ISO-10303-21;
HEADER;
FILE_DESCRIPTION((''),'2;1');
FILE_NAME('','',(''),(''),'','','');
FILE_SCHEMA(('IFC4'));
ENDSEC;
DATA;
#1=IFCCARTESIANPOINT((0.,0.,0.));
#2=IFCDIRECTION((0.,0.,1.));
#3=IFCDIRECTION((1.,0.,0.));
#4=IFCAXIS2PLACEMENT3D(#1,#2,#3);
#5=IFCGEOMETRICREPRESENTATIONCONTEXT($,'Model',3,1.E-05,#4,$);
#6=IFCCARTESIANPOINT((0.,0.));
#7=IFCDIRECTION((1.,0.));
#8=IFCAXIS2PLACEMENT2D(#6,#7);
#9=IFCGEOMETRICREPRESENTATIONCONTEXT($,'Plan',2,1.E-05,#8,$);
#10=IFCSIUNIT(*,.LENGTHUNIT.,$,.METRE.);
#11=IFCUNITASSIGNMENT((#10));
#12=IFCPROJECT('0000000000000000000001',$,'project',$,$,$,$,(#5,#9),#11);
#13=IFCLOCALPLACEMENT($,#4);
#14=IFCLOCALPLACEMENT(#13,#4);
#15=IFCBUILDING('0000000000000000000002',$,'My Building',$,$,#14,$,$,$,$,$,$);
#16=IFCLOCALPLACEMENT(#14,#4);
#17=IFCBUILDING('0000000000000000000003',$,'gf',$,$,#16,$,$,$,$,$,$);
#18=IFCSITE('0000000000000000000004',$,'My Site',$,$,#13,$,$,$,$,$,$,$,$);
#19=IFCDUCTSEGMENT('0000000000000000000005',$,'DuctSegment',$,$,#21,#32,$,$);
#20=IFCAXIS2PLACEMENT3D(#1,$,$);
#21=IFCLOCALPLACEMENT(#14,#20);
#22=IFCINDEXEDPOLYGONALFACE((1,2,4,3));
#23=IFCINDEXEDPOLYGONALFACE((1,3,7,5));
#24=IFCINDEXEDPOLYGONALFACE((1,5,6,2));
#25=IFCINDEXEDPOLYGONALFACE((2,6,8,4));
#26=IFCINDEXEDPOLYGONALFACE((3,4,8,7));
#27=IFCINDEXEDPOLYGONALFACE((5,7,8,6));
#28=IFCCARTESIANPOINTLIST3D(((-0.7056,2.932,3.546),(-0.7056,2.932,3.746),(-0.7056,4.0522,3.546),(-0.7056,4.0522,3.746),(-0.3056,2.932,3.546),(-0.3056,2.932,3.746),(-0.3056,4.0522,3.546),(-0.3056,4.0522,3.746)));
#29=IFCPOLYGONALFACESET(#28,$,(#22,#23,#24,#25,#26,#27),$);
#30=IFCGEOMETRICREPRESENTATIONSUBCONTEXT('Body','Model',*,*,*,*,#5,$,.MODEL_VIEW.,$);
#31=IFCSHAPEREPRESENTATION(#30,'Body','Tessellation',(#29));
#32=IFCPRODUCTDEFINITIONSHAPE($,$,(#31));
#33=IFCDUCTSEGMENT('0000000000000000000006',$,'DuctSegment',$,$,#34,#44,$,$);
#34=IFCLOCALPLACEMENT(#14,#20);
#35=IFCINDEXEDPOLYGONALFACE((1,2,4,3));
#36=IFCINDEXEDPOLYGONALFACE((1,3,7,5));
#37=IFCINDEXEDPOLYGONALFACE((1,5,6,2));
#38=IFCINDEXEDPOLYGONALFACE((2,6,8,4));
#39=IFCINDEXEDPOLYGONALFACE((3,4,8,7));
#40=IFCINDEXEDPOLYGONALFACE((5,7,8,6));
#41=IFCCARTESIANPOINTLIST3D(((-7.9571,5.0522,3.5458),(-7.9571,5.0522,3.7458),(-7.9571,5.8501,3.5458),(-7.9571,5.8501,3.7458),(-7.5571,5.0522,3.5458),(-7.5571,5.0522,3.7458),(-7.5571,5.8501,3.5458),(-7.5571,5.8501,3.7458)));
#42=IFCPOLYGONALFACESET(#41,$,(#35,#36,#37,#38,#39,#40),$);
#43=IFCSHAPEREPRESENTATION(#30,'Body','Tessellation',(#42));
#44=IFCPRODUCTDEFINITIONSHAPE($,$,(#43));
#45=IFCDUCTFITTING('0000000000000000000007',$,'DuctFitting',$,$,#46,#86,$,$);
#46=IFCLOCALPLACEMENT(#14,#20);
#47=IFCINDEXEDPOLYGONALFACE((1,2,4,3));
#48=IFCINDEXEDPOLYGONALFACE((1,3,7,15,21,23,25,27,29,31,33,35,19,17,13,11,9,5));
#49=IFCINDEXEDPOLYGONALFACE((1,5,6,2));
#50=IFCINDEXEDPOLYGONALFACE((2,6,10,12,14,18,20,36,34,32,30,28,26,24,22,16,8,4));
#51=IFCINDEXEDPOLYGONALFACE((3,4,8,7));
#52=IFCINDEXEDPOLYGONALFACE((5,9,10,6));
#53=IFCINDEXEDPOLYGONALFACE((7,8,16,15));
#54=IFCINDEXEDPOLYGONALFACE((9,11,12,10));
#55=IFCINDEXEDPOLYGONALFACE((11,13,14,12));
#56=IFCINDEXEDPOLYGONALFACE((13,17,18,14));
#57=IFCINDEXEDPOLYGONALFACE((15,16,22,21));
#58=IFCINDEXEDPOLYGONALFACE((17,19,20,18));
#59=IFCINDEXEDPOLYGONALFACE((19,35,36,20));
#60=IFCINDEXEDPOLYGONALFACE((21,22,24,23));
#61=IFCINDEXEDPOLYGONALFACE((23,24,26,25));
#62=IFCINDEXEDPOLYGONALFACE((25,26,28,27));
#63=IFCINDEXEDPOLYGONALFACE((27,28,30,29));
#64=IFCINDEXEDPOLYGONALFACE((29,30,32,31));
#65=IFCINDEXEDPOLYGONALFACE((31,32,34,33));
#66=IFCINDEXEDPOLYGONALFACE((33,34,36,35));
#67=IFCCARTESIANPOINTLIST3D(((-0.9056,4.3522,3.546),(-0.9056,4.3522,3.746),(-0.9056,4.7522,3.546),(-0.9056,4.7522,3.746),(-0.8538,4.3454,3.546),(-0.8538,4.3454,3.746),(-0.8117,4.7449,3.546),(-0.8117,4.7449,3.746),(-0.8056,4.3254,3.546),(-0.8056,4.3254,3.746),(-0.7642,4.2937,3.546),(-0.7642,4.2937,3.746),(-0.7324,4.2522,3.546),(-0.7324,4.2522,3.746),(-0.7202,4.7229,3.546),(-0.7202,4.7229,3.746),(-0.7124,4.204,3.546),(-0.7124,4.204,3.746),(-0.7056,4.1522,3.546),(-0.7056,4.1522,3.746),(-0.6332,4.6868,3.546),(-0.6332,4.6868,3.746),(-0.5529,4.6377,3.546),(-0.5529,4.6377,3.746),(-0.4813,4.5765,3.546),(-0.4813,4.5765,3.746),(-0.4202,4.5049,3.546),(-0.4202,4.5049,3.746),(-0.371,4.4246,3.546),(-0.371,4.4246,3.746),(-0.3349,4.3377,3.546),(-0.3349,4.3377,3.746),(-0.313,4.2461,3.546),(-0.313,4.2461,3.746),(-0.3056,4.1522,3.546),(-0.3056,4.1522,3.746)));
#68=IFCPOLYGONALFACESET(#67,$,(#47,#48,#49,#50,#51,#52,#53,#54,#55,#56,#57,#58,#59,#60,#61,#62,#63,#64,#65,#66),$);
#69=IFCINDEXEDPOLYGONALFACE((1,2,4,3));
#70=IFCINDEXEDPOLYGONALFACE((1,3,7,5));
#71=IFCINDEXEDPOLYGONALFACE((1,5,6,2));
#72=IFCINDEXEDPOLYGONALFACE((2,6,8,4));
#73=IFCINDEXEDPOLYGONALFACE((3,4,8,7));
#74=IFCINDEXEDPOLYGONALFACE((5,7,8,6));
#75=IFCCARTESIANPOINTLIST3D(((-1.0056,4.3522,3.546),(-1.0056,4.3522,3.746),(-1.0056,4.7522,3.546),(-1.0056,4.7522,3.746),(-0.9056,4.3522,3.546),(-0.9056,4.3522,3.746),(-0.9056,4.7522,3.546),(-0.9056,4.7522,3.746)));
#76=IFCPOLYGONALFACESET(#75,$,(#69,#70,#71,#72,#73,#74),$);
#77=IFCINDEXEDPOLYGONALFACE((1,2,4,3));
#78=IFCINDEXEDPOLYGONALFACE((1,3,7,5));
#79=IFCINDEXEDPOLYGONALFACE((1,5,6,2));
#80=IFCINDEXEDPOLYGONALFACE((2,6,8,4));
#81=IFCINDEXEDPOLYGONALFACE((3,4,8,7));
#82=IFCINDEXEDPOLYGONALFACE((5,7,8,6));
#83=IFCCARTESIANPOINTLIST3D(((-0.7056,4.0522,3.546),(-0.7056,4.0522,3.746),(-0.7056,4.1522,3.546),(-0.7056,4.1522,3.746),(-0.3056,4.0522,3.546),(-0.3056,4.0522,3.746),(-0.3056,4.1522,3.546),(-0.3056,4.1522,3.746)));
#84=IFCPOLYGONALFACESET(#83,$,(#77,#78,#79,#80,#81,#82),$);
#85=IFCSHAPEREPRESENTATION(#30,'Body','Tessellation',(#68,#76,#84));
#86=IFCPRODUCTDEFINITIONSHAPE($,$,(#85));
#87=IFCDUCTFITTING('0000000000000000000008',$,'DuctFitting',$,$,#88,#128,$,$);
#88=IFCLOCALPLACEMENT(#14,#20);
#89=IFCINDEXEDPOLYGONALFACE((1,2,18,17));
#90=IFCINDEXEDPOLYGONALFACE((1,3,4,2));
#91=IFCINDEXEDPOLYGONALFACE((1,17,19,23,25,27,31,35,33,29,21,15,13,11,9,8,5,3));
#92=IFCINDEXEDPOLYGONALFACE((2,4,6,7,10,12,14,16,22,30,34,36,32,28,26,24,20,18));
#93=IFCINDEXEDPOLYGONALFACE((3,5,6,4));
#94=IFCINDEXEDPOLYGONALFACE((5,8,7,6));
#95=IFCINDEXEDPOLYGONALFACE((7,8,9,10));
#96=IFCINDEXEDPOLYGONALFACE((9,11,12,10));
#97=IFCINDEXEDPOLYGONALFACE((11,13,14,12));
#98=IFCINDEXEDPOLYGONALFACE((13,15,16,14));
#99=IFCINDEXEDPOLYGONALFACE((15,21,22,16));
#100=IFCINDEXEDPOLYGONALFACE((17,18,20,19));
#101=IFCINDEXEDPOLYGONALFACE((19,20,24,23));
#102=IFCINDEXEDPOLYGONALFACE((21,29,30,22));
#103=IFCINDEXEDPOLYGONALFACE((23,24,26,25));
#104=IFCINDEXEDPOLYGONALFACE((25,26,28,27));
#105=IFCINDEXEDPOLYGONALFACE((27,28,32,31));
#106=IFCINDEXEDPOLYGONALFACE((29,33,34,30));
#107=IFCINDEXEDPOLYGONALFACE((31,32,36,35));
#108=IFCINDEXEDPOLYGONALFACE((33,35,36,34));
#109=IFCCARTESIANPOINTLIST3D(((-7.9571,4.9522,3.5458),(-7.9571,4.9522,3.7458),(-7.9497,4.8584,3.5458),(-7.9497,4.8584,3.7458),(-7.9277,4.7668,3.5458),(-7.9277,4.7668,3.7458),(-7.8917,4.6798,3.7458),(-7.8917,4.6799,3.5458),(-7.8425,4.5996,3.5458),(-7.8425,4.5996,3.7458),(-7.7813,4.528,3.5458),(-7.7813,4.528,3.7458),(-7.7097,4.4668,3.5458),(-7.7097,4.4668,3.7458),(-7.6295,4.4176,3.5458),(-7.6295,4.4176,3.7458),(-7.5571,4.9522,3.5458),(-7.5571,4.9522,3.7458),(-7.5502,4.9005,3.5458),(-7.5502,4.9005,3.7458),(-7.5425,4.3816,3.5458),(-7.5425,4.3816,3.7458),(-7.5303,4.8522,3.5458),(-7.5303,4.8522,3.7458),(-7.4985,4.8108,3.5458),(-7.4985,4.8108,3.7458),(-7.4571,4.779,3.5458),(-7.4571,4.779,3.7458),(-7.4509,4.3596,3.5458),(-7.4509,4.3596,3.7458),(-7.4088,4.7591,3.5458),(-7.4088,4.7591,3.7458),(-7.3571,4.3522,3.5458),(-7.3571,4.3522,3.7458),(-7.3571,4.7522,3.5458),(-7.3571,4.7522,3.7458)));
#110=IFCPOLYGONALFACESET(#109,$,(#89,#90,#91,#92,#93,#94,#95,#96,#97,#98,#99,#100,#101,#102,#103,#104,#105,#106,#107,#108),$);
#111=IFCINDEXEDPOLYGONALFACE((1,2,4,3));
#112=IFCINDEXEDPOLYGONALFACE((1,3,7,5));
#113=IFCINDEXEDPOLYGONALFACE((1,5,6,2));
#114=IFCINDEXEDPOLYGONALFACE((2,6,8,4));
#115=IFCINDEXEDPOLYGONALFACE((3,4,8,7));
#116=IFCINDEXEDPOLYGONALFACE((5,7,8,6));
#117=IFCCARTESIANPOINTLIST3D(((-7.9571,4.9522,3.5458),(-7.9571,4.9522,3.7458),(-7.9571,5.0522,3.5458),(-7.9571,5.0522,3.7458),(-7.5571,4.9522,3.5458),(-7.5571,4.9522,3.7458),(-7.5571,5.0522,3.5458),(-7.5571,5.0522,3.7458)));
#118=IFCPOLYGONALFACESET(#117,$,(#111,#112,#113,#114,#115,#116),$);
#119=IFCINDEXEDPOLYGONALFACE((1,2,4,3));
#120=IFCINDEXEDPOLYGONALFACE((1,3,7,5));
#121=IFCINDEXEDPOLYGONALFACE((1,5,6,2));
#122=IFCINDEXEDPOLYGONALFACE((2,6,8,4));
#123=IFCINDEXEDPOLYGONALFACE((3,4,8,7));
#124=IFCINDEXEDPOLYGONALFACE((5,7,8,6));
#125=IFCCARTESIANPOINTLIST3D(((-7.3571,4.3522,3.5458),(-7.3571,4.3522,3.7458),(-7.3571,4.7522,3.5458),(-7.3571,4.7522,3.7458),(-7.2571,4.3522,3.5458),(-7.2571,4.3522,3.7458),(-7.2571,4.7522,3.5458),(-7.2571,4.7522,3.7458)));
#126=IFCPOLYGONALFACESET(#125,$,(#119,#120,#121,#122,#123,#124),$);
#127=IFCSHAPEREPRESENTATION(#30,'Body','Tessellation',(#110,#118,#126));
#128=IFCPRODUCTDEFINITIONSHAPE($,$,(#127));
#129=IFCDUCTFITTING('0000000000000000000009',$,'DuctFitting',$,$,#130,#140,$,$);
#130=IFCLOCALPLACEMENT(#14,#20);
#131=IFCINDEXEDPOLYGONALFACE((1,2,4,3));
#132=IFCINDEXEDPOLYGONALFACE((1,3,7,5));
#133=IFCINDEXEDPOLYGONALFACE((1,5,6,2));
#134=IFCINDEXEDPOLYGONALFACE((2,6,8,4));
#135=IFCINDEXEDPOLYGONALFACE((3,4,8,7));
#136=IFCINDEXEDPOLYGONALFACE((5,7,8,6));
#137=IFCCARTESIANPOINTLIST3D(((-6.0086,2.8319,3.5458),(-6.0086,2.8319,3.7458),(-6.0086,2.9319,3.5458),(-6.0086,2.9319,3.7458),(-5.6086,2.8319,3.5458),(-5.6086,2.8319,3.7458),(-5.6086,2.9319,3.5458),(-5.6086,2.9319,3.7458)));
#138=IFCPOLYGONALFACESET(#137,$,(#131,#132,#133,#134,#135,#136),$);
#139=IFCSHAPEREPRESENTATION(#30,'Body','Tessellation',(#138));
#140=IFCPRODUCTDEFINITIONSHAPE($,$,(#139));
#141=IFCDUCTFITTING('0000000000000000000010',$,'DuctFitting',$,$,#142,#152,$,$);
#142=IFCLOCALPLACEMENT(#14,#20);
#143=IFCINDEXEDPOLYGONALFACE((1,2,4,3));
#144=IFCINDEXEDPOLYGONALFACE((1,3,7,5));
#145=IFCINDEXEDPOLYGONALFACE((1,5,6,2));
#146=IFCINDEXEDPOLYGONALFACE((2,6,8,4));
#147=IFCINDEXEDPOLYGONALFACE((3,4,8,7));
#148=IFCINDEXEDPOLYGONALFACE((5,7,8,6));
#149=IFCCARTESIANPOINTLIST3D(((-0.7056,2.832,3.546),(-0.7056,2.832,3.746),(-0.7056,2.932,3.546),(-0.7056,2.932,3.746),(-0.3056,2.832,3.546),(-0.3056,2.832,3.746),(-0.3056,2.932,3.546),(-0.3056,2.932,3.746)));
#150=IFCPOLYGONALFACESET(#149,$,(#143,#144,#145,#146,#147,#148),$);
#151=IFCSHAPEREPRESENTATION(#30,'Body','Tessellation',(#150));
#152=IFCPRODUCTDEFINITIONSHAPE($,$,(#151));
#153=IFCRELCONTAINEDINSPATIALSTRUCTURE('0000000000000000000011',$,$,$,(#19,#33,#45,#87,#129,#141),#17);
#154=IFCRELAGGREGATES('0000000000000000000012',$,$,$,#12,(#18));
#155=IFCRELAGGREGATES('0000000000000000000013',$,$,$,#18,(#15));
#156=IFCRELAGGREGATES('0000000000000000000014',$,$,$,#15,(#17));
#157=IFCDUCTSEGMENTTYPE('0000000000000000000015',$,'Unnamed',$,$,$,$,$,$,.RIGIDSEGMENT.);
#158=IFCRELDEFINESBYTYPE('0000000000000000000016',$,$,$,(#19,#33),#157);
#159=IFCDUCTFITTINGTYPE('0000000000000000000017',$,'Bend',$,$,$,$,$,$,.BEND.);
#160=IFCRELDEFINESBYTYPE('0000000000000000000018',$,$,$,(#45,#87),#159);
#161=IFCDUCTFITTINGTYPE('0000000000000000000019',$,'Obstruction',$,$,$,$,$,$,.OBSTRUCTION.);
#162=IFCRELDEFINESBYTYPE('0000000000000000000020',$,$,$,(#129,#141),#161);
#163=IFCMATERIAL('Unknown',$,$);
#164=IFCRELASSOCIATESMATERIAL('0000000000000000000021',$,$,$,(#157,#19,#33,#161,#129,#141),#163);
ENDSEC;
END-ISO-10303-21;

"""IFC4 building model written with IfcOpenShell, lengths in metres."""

from ifc_helpers import new_model, si_unit, frame, origin_with_axes, origin_2d_with_axis, place, context, subcontext, project, spatial, line, arc, indexed_curve, rectangle, outline, extrude, source, transform, mapped, material, material_profile, profile_set, profile_usage, type_object, type_shapes, element, save


model = new_model("IFC4")

# Units and contexts
model_context = context("Model", 3, precision=1e-05, world=origin_with_axes())
plan_context = context("Plan", 2, precision=1e-05, world=origin_2d_with_axis())
body_context_1 = subcontext(model_context, "Body", "Model", "MODEL_VIEW")
ifc_project = project(units=[si_unit("LENGTHUNIT", "METRE")], contexts=[model_context, plan_context])

# Site, buildings
site_placement = place(None, origin_with_axes())
site = spatial("IfcSite", under=ifc_project, at=site_placement, Name="My Site")
building_1_placement = place(site_placement, origin_with_axes())
building_1 = spatial("IfcBuilding", under=site, at=building_1_placement, Name="My Building")
building_2_placement = place(building_1_placement, origin_with_axes())
building_2 = spatial("IfcBuilding", under=building_1, at=building_2_placement, Name="gf")

# Shared definitions
ifc_material = material(Name="Unknown")

# Duct segments
ifc_material_profile_1 = material_profile(ifc_material, rectangle(XDim=0.4, YDim=0.2))
ifc_profile_set_1 = profile_set([ifc_material_profile_1])
duct_segment_type = type_object("IfcDuctSegmentType", Name="Unnamed", PredefinedType="RIGIDSEGMENT", material=ifc_profile_set_1)
ifc_profile_usage_1 = profile_usage(ifc_profile_set_1, cardinal=5)
duct_segment_1_placement = place(building_2_placement, frame((-0.5056, 2.932, 3.646), z_axis=(0.0, 1.0, 0.0), x_axis=(-1.0, 0.0, 0.0)))
element("IfcDuctSegment", 1, at=duct_segment_1_placement, inside=building_2, type_object=duct_segment_type, material=ifc_profile_usage_1, Name="DuctSegment", context=body_context_1, shape_type="SweptSolid", body=[
    extrude(rectangle(XDim=0.4, YDim=0.2), origin_with_axes(), (0.0, 0.0, 1.0), 1.1203),
])
ifc_profile_usage_2 = profile_usage(ifc_profile_set_1, cardinal=5)
duct_segment_2_placement = place(building_2_placement, frame((-7.7571, 5.0522, 3.6458), z_axis=(0.0, 1.0, 0.0), x_axis=(-1.0, 0.0, 0.0)))
element("IfcDuctSegment", 2, at=duct_segment_2_placement, inside=building_2, type_object=duct_segment_type, material=ifc_profile_usage_2, Name="DuctSegment", context=body_context_1, shape_type="SweptSolid", body=[
    extrude(rectangle(XDim=0.4, YDim=0.2), origin_with_axes(), (0.0, 0.0, 1.0), 0.7979),
])

# Duct fittings
duct_fitting_type_1 = type_object("IfcDuctFittingType", Name="Bend", PredefinedType="BEND")
shared_shape_1 = source(origin_with_axes(), body_context_1, "Body", "SweptSolid", [
    extrude(outline(indexed_curve([(-0.2, 0.0), (-0.2586, 0.1414), (-0.4, 0.2), (-0.4, 0.6), (0.0243, 0.4243), (0.2, 0.0)], segments=[arc(1, 2, 3), line(3, 4), arc(4, 5, 6), line(6, 1)])), frame((0.0, -0.1, 0.1), z_axis=(0.0, -1.0, 0.0), x_axis=(1.0, 0.0, 0.0)), (0.0, 0.0, -1.0), 0.2),
    extrude(rectangle(XDim=0.4, YDim=0.2), origin_with_axes(), (0.0, 0.0, 1.0), 0.1),
    extrude(rectangle(XDim=0.4, YDim=0.2), frame((-0.4, 0.0, 0.5), z_axis=(-1.0, 0.0, 0.0), x_axis=(0.0, 0.0, -1.0)), (0.0, 0.0, 1.0), 0.1),
])
type_shapes(duct_fitting_type_1, [shared_shape_1])
for number, where, z_axis, x_axis, name in (
    (3, (-1.0056, 4.5522, 3.646), (1.0, 0.0, 0.000029), (0.0, 1.0, 0.0), "DuctFitting"),
    (4, (-7.7571, 5.0522, 3.6458), (0.0, -1.0, -0.000029), (-1.0, 0.0, 0.0), "DuctFitting"),
):
    element("IfcDuctFitting", number, at=place(building_2_placement, frame(where, z_axis=z_axis, x_axis=x_axis)), inside=building_2, type_object=duct_fitting_type_1, Name=name, context=body_context_1, shape_type="MappedRepresentation", body=[
        mapped(shared_shape_1, transform((0.0, 0.0, 0.0), x_axis=(1.0, 0.0, 0.0), y_axis=(0.0, 1.0, 0.0), z_axis=(0.0, 0.0, 1.0), scale=1.0)),
    ])
ifc_material_profile_2 = material_profile(ifc_material, rectangle(XDim=0.4, YDim=0.2))
ifc_profile_set_2 = profile_set([ifc_material_profile_2])
ifc_profile_usage_3 = profile_usage(ifc_profile_set_2, cardinal=5)
duct_fitting_type_2 = type_object("IfcDuctFittingType", Name="Obstruction", PredefinedType="OBSTRUCTION", material=ifc_profile_set_2)
duct_fitting_1_placement = place(building_2_placement, frame((-5.8086, 2.8319, 3.6458), z_axis=(0.0, 1.0, 0.0), x_axis=(-1.0, 0.0, 0.0)))
element("IfcDuctFitting", 5, at=duct_fitting_1_placement, inside=building_2, type_object=duct_fitting_type_2, material=ifc_profile_usage_3, Name="DuctFitting", context=body_context_1, shape_type="SweptSolid", body=[
    extrude(rectangle(XDim=0.4, YDim=0.2), origin_with_axes(), (0.0, 0.0, 1.0), 0.1),
])
ifc_profile_usage_4 = profile_usage(ifc_profile_set_2, cardinal=5)
duct_fitting_2_placement = place(building_2_placement, frame((-0.5056, 2.832, 3.646), z_axis=(0.0, 1.0, 0.0), x_axis=(-1.0, 0.0, 0.0)))
element("IfcDuctFitting", 6, at=duct_fitting_2_placement, inside=building_2, type_object=duct_fitting_type_2, material=ifc_profile_usage_4, Name="DuctFitting", context=body_context_1, shape_type="SweptSolid", body=[
    extrude(rectangle(XDim=0.4, YDim=0.2), origin_with_axes(), (0.0, 0.0, 1.0), 0.1),
])

save(model, "model.ifc")
